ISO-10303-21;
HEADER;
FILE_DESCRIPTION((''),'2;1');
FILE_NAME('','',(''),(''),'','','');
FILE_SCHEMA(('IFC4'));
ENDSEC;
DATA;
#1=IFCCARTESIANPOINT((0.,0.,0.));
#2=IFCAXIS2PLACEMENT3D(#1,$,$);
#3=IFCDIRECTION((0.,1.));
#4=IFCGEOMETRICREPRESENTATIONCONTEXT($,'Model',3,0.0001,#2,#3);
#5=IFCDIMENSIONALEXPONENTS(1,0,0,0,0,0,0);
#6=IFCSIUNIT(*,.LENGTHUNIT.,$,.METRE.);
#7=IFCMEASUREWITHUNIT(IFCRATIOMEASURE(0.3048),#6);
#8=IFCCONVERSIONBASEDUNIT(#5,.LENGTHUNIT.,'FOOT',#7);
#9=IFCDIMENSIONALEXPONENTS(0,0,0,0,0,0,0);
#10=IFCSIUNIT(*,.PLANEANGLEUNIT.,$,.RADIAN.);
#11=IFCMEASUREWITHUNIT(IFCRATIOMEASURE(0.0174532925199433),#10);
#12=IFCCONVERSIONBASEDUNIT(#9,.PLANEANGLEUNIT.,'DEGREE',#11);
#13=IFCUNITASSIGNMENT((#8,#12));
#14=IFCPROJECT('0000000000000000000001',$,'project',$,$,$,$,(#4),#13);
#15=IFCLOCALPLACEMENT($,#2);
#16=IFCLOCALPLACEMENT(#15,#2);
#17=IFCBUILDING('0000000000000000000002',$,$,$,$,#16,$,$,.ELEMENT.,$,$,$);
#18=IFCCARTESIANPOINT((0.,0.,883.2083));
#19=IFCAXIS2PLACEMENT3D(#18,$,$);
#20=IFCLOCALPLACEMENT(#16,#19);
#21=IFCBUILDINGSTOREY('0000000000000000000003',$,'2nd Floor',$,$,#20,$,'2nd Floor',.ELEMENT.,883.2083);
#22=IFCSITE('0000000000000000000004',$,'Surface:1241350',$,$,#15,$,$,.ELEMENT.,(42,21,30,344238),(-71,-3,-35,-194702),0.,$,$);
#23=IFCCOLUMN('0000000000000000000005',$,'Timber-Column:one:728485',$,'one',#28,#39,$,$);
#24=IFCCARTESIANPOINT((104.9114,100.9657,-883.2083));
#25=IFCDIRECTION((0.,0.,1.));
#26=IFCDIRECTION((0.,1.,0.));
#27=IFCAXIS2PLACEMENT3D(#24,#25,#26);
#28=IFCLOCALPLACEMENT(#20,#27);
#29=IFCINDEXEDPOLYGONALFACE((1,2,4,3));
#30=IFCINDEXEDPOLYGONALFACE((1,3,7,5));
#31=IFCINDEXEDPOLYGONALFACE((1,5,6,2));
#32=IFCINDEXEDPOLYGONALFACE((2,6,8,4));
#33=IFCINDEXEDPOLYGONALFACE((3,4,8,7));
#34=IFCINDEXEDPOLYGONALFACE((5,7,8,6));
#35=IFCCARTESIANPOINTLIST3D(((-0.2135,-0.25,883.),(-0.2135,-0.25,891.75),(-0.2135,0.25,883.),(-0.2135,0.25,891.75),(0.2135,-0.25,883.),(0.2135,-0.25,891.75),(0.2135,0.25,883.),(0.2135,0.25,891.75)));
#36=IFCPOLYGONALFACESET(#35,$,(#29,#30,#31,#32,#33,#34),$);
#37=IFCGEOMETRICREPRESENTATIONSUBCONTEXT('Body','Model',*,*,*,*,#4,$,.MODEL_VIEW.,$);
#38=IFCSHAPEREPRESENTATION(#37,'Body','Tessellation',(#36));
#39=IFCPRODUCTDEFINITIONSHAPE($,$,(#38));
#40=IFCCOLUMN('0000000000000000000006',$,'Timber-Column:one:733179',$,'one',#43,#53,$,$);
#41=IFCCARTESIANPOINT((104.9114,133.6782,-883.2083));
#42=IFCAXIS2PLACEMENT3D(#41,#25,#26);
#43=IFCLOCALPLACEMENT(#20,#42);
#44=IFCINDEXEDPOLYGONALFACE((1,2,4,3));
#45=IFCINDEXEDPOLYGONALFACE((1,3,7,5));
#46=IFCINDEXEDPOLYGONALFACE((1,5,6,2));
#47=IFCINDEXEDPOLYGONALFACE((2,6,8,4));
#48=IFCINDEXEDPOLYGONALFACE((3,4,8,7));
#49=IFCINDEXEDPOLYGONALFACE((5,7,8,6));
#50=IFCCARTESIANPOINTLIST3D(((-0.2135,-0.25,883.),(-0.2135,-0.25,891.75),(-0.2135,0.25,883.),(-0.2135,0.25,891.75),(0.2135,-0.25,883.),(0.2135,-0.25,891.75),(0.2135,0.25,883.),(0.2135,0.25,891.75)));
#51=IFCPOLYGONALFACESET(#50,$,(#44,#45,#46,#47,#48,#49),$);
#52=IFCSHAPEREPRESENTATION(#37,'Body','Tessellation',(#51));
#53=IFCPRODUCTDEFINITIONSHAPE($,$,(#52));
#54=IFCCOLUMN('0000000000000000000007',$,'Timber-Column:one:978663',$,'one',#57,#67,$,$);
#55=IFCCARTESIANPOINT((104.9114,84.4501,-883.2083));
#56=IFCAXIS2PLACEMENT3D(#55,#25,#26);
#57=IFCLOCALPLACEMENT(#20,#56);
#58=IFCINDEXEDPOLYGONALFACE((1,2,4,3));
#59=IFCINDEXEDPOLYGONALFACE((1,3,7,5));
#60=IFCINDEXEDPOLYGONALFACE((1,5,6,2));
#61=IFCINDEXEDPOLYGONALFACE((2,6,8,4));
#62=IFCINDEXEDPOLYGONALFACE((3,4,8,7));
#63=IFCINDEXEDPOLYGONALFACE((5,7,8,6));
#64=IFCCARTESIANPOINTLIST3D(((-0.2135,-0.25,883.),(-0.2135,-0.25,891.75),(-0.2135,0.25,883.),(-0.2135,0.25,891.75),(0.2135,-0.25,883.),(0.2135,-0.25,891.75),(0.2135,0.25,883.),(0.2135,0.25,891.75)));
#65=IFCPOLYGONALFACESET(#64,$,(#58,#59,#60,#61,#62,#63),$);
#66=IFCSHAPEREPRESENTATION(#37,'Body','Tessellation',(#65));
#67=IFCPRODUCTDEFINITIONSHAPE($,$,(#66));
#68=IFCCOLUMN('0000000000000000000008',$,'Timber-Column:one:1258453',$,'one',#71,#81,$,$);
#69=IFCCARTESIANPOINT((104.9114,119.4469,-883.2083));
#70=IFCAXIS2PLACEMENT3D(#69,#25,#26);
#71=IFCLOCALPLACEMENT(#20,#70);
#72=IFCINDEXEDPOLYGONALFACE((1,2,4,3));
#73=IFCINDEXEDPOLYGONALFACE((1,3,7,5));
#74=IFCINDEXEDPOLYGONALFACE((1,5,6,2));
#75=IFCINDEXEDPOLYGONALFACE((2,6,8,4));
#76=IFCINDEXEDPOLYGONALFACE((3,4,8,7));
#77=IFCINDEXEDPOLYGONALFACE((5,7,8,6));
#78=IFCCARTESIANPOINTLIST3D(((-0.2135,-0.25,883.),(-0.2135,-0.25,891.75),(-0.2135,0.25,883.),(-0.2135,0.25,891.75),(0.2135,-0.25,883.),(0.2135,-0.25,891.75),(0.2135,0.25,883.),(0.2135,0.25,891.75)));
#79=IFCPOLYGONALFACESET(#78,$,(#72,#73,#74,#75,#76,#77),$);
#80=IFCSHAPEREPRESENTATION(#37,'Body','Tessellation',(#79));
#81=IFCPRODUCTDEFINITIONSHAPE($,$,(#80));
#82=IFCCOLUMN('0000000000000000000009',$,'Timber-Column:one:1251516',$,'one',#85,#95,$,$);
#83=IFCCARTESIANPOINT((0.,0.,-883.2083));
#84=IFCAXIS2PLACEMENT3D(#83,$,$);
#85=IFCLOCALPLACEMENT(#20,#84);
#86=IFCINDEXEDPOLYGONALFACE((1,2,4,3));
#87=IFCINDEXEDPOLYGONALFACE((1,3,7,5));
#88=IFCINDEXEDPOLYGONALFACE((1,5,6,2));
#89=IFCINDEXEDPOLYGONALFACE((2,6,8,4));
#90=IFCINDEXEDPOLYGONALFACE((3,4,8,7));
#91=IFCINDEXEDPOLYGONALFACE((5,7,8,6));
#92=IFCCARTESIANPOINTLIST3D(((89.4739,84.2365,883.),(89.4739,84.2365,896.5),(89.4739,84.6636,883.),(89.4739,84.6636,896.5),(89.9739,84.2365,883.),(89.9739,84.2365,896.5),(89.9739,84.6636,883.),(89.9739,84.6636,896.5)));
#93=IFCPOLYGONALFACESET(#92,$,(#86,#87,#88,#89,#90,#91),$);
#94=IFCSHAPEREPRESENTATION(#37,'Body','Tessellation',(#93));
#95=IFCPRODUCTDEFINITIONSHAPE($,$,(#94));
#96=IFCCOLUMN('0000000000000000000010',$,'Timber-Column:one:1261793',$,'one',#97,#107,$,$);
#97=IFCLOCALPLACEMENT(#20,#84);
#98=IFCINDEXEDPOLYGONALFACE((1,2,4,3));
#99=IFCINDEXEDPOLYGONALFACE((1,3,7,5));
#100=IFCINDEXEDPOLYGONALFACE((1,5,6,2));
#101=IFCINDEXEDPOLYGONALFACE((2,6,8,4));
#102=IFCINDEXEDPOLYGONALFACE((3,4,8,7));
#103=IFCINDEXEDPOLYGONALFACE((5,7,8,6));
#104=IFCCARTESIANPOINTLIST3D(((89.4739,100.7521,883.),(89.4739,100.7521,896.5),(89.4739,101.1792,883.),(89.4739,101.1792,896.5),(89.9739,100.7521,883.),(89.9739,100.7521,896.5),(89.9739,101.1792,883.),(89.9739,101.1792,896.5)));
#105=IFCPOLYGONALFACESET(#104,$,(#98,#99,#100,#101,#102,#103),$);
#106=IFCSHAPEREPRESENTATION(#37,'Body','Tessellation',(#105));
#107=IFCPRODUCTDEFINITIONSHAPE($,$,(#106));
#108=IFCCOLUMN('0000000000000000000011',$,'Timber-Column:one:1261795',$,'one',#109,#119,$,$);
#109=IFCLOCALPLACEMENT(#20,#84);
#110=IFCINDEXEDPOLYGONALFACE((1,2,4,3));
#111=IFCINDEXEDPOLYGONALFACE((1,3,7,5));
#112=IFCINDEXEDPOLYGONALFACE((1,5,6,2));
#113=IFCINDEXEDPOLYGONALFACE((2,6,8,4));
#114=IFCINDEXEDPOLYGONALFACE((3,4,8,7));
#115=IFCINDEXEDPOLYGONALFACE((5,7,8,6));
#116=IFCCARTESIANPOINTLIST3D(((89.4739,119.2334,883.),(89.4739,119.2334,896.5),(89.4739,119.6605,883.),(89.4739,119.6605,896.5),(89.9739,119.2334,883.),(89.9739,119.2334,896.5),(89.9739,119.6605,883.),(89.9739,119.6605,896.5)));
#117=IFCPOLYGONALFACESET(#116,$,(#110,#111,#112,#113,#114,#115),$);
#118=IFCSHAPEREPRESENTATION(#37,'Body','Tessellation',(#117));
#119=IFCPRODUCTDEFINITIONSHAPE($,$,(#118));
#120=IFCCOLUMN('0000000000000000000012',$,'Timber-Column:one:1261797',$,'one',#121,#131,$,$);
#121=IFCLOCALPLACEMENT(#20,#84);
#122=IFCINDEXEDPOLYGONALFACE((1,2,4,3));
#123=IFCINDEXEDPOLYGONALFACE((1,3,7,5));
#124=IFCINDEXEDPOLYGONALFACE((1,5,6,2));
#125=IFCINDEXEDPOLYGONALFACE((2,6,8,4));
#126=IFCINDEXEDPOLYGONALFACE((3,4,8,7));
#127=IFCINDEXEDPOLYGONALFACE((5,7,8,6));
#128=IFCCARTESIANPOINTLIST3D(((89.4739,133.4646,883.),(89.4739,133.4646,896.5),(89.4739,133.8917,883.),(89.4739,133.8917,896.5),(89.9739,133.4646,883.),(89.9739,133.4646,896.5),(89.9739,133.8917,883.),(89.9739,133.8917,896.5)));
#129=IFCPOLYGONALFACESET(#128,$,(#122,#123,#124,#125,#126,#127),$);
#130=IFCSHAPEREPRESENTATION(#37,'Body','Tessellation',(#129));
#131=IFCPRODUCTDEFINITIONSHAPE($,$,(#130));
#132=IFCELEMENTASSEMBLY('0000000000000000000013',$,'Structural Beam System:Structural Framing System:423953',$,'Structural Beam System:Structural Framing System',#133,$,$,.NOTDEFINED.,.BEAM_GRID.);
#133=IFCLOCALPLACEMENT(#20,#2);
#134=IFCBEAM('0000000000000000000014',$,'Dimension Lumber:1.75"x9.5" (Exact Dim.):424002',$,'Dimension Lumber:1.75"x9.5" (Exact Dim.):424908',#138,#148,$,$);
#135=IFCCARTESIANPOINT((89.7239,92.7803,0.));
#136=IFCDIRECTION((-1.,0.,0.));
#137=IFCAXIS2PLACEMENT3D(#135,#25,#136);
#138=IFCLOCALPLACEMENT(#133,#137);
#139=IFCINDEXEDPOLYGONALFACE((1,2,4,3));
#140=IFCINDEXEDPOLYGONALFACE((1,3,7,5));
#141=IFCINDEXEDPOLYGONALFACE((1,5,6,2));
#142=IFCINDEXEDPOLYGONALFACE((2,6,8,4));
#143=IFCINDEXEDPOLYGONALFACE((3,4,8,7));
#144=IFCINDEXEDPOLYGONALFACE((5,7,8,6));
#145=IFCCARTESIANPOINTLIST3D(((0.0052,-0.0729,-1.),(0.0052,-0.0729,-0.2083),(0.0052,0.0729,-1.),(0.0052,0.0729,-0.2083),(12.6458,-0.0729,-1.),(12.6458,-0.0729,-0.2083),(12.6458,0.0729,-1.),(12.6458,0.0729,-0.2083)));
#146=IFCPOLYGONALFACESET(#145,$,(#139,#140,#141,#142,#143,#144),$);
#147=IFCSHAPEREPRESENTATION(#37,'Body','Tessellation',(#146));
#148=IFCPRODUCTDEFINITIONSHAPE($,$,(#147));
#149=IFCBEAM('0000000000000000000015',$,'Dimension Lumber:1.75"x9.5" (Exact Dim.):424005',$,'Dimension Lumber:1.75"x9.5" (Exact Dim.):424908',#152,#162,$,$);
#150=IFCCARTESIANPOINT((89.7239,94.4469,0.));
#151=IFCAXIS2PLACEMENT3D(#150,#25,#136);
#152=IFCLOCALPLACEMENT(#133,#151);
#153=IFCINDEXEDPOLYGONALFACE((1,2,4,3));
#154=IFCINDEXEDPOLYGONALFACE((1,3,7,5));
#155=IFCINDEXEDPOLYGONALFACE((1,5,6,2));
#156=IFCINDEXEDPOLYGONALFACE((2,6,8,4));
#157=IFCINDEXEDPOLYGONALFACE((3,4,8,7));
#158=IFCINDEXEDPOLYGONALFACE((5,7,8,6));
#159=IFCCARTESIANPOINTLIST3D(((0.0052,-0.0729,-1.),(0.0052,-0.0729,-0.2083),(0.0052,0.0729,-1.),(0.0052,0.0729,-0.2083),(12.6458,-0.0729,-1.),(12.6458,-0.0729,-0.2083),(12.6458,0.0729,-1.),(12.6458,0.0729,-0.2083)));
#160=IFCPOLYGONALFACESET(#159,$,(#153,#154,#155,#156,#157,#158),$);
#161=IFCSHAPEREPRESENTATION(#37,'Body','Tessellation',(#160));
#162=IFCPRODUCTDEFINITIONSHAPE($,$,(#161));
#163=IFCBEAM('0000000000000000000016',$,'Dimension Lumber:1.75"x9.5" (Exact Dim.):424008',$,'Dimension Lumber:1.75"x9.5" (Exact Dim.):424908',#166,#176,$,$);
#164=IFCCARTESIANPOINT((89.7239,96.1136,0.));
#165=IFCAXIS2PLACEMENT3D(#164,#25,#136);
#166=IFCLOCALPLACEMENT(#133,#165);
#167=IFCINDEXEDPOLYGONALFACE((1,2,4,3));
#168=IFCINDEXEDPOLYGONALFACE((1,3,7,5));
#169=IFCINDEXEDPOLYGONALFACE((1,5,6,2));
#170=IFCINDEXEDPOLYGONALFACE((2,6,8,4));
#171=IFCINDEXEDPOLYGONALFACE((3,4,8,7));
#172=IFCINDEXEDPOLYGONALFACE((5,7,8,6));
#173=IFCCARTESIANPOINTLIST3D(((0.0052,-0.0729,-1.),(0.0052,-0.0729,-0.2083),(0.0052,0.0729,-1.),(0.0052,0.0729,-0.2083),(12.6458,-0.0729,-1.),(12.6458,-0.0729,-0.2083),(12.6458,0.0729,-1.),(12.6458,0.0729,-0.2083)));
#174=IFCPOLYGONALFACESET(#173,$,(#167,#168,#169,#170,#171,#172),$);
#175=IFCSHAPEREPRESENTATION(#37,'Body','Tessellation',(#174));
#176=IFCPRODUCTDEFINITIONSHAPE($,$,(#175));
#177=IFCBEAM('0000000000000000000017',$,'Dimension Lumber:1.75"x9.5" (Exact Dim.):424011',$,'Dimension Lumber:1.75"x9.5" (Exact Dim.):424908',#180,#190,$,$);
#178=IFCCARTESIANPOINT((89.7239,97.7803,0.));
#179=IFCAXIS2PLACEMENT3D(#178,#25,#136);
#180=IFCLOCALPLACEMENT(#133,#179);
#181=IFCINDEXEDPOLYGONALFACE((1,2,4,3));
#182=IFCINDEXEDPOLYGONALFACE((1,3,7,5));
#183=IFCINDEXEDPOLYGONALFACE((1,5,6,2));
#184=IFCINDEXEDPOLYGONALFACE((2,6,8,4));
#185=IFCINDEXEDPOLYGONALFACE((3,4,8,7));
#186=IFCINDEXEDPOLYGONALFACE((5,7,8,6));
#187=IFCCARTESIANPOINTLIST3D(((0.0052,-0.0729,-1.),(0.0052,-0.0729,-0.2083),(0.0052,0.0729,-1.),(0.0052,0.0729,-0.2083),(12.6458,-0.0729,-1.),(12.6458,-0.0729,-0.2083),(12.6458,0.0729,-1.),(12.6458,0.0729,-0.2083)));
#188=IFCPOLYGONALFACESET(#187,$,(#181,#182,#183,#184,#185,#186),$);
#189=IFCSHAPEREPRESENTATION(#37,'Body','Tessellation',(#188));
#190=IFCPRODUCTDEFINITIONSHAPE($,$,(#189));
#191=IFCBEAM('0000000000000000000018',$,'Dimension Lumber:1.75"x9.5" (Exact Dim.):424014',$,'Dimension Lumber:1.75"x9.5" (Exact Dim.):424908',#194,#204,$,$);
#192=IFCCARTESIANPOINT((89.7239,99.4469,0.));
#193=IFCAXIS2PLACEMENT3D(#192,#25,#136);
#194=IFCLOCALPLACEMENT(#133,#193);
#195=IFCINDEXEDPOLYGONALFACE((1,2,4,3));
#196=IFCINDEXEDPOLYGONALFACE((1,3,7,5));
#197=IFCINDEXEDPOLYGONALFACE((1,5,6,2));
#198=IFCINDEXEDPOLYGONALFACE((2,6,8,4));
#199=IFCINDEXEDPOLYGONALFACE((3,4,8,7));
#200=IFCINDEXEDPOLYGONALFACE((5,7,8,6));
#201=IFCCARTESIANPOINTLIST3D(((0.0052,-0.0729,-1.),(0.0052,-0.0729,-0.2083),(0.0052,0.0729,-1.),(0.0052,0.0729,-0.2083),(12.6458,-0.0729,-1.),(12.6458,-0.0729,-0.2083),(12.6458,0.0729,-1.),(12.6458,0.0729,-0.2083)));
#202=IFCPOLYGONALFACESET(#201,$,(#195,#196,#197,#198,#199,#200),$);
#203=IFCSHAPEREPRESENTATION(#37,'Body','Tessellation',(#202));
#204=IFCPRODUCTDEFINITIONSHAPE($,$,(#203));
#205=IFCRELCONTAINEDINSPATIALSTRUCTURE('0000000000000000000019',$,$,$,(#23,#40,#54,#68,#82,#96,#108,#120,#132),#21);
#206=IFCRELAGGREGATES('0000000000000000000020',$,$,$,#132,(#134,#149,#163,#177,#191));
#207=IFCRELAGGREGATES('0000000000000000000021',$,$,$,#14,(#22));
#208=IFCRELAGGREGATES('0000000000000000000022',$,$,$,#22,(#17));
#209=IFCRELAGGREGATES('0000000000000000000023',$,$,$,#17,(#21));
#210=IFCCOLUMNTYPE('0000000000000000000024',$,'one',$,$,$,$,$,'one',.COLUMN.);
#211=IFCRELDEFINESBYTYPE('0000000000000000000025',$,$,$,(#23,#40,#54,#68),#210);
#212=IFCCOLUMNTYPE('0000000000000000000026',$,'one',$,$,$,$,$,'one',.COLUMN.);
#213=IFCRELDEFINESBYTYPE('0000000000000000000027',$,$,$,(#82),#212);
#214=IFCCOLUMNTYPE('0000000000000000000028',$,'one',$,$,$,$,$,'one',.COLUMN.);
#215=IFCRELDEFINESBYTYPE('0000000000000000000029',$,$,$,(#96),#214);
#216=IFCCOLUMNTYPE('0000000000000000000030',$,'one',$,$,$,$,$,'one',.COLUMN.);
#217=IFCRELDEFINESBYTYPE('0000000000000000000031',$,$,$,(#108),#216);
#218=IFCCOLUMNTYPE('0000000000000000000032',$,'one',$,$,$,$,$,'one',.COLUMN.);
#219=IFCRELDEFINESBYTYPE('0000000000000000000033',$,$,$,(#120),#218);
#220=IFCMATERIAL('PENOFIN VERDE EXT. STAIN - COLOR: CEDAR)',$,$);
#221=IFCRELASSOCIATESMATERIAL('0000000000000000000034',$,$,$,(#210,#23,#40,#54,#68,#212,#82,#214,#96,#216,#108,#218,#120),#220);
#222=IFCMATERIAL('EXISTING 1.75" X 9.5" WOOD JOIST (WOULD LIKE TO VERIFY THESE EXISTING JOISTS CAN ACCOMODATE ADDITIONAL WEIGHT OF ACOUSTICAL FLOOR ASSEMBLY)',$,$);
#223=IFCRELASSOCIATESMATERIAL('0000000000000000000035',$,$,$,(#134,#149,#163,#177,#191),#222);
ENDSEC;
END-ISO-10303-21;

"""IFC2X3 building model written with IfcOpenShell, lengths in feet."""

from ifc_helpers import new_model, entity, si_unit, converted_unit, direction, frame, origin, origin_2d_with_axis, place, context, subcontext, project, spatial, rectangle, extrude, source, transform, mapped, material, type_object, type_shapes, element, aggregate, save


model = new_model("IFC2X3")

# Units and contexts
model_context = context("Model", 3, precision=0.0001, world=origin(), true_north=direction((0.0, 1.0)))
body_context = subcontext(model_context, "Body", "Model", "MODEL_VIEW")
ifc_project = project(units=[converted_unit("LENGTHUNIT", "FOOT", entity("IfcRatioMeasure", 0.3048), si_unit("LENGTHUNIT", "METRE"), dimensions=[1, 0, 0, 0, 0, 0, 0]), converted_unit("PLANEANGLEUNIT", "DEGREE", entity("IfcRatioMeasure", 0.0174532925199433), si_unit("PLANEANGLEUNIT", "RADIAN"), dimensions=[0, 0, 0, 0, 0, 0, 0])], contexts=[model_context])

# Site, building, storey
site_placement = place(None, origin())
site = spatial("IfcSite", under=ifc_project, at=site_placement, Name="Surface:1241350", CompositionType="ELEMENT", RefLatitude=(42, 21, 30, 344238), RefLongitude=(-71, -3, -35, -194702), RefElevation=0.0)
building_placement = place(site_placement, origin())
building = spatial("IfcBuilding", under=site, at=building_placement, CompositionType="ELEMENT")
storey_placement = place(building_placement, frame((0.0, 0.0, 883.2083)))
storey = spatial("IfcBuildingStorey", under=building, at=storey_placement, Name="2nd Floor", LongName="2nd Floor", CompositionType="ELEMENT", Elevation=883.2083)

# Columns
ifc_material_1 = material(Name="PENOFIN VERDE EXT. STAIN - COLOR: CEDAR)")
column_type_1 = type_object("IfcColumnType", Name="one", ElementType="one", PredefinedType="COLUMN", material=ifc_material_1)
shared_shape_1 = source(origin(), body_context, "Body", "SweptSolid", [
    extrude(rectangle(XDim=0.5, YDim=0.4271, at=origin_2d_with_axis()), frame((0.0, 0.0, 883.0), z_axis=(0.0, 0.0, 1.0), x_axis=(0.0, -1.0, 0.0)), (0.0, 0.0, 1.0), 8.75),
])
type_shapes(column_type_1, [shared_shape_1])
for number, where, z_axis, x_axis, name in (
    (1, (104.9114, 100.9657, -883.2083), (0.0, 0.0, 1.0), (0.0, 1.0, 0.0), "Timber-Column:one:728485"),
    (2, (104.9114, 133.6782, -883.2083), (0.0, 0.0, 1.0), (0.0, 1.0, 0.0), "Timber-Column:one:733179"),
    (3, (104.9114, 84.4501, -883.2083), (0.0, 0.0, 1.0), (0.0, 1.0, 0.0), "Timber-Column:one:978663"),
    (4, (104.9114, 119.4469, -883.2083), (0.0, 0.0, 1.0), (0.0, 1.0, 0.0), "Timber-Column:one:1258453"),
):
    element("IfcColumn", number, at=place(storey_placement, frame(where, z_axis=z_axis, x_axis=x_axis)), inside=storey, type_object=column_type_1, material=ifc_material_1, Name=name, ObjectType="one", context=body_context, shape_type="MappedRepresentation", body=[
        mapped(shared_shape_1, transform((0.0, 0.0, 0.0), scale=1.0)),
    ])
column_type_2 = type_object("IfcColumnType", Name="one", ElementType="one", PredefinedType="COLUMN", material=ifc_material_1)
shared_shape_2 = source(origin(), body_context, "Body", "SweptSolid", [
    extrude(rectangle(XDim=0.4271, YDim=0.5, at=origin_2d_with_axis()), frame((89.7239, 84.4501, 883.0), z_axis=(0.0, 0.0, 1.0), x_axis=(0.0, -1.0, 0.0)), (0.0, 0.0, 1.0), 13.5),
])
type_shapes(column_type_2, [shared_shape_2])
column_1_placement = place(storey_placement, frame((0.0, 0.0, -883.2083)))
element("IfcColumn", 5, at=column_1_placement, inside=storey, type_object=column_type_2, material=ifc_material_1, Name="Timber-Column:one:1251516", ObjectType="one", context=body_context, shape_type="MappedRepresentation", body=[
    mapped(shared_shape_2, transform((0.0, 0.0, 0.0), scale=1.0)),
])
column_type_3 = type_object("IfcColumnType", Name="one", ElementType="one", PredefinedType="COLUMN", material=ifc_material_1)
shared_shape_3 = source(origin(), body_context, "Body", "SweptSolid", [
    extrude(rectangle(XDim=0.4271, YDim=0.5, at=origin_2d_with_axis()), frame((89.7239, 100.9657, 883.0), z_axis=(0.0, 0.0, 1.0), x_axis=(0.0, -1.0, 0.0)), (0.0, 0.0, 1.0), 13.5),
])
type_shapes(column_type_3, [shared_shape_3])
column_2_placement = place(storey_placement, frame((0.0, 0.0, -883.2083)))
element("IfcColumn", 6, at=column_2_placement, inside=storey, type_object=column_type_3, material=ifc_material_1, Name="Timber-Column:one:1261793", ObjectType="one", context=body_context, shape_type="MappedRepresentation", body=[
    mapped(shared_shape_3, transform((0.0, 0.0, 0.0), scale=1.0)),
])
column_type_4 = type_object("IfcColumnType", Name="one", ElementType="one", PredefinedType="COLUMN", material=ifc_material_1)
shared_shape_4 = source(origin(), body_context, "Body", "SweptSolid", [
    extrude(rectangle(XDim=0.4271, YDim=0.5, at=origin_2d_with_axis()), frame((89.7239, 119.4469, 883.0), z_axis=(0.0, 0.0, 1.0), x_axis=(0.0, -1.0, 0.0)), (0.0, 0.0, 1.0), 13.5),
])
type_shapes(column_type_4, [shared_shape_4])
column_3_placement = place(storey_placement, frame((0.0, 0.0, -883.2083)))
element("IfcColumn", 7, at=column_3_placement, inside=storey, type_object=column_type_4, material=ifc_material_1, Name="Timber-Column:one:1261795", ObjectType="one", context=body_context, shape_type="MappedRepresentation", body=[
    mapped(shared_shape_4, transform((0.0, 0.0, 0.0), scale=1.0)),
])
column_type_5 = type_object("IfcColumnType", Name="one", ElementType="one", PredefinedType="COLUMN", material=ifc_material_1)
shared_shape_5 = source(origin(), body_context, "Body", "SweptSolid", [
    extrude(rectangle(XDim=0.4271, YDim=0.5, at=origin_2d_with_axis()), frame((89.7239, 133.6782, 883.0), z_axis=(0.0, 0.0, 1.0), x_axis=(0.0, -1.0, 0.0)), (0.0, 0.0, 1.0), 13.5),
])
type_shapes(column_type_5, [shared_shape_5])
column_4_placement = place(storey_placement, frame((0.0, 0.0, -883.2083)))
element("IfcColumn", 8, at=column_4_placement, inside=storey, type_object=column_type_5, material=ifc_material_1, Name="Timber-Column:one:1261797", ObjectType="one", context=body_context, shape_type="MappedRepresentation", body=[
    mapped(shared_shape_5, transform((0.0, 0.0, 0.0), scale=1.0)),
])

# Element assembly, beams
assembly_placement = place(storey_placement, origin())
assembly = element("IfcElementAssembly", 9, at=assembly_placement, inside=storey, Name="Structural Beam System:Structural Framing System:423953", ObjectType="Structural Beam System:Structural Framing System", AssemblyPlace="NOTDEFINED", PredefinedType="BEAM_GRID")
ifc_material_2 = material(Name="EXISTING 1.75\" X 9.5\" WOOD JOIST (WOULD LIKE TO VERIFY THESE EXISTING JOISTS CAN ACCOMODATE ADDITIONAL WEIGHT OF ACOUSTICAL FLOOR ASSEMBLY)")
beam_1_placement = place(assembly_placement, frame((89.7239, 92.7803, 0.0), z_axis=(0.0, 0.0, 1.0), x_axis=(-1.0, 0.0, 0.0)))
beam_1 = element("IfcBeam", 10, at=beam_1_placement, material=ifc_material_2, Name="Dimension Lumber:1.75\"x9.5\" (Exact Dim.):424002", ObjectType="Dimension Lumber:1.75\"x9.5\" (Exact Dim.):424908", context=body_context, shape_type="SweptSolid", body=[
    extrude(rectangle(XDim=0.7917, YDim=0.1458, at=origin_2d_with_axis()), frame((0.0052, 0.0, -0.6042), z_axis=(1.0, 0.0, 0.0), x_axis=(0.0, 0.0, -1.0)), (0.0, 0.0, 1.0), 12.6406),
])
beam_2_placement = place(assembly_placement, frame((89.7239, 94.4469, 0.0), z_axis=(0.0, 0.0, 1.0), x_axis=(-1.0, 0.0, 0.0)))
beam_2 = element("IfcBeam", 11, at=beam_2_placement, material=ifc_material_2, Name="Dimension Lumber:1.75\"x9.5\" (Exact Dim.):424005", ObjectType="Dimension Lumber:1.75\"x9.5\" (Exact Dim.):424908", context=body_context, shape_type="SweptSolid", body=[
    extrude(rectangle(XDim=0.7917, YDim=0.1458, at=origin_2d_with_axis()), frame((0.0052, 0.0, -0.6042), z_axis=(1.0, 0.0, 0.0), x_axis=(0.0, 0.0, -1.0)), (0.0, 0.0, 1.0), 12.6406),
])
beam_3_placement = place(assembly_placement, frame((89.7239, 96.1136, 0.0), z_axis=(0.0, 0.0, 1.0), x_axis=(-1.0, 0.0, 0.0)))
beam_3 = element("IfcBeam", 12, at=beam_3_placement, material=ifc_material_2, Name="Dimension Lumber:1.75\"x9.5\" (Exact Dim.):424008", ObjectType="Dimension Lumber:1.75\"x9.5\" (Exact Dim.):424908", context=body_context, shape_type="SweptSolid", body=[
    extrude(rectangle(XDim=0.7917, YDim=0.1458, at=origin_2d_with_axis()), frame((0.0052, 0.0, -0.6042), z_axis=(1.0, 0.0, 0.0), x_axis=(0.0, 0.0, -1.0)), (0.0, 0.0, 1.0), 12.6406),
])
beam_4_placement = place(assembly_placement, frame((89.7239, 97.7803, 0.0), z_axis=(0.0, 0.0, 1.0), x_axis=(-1.0, 0.0, 0.0)))
beam_4 = element("IfcBeam", 13, at=beam_4_placement, material=ifc_material_2, Name="Dimension Lumber:1.75\"x9.5\" (Exact Dim.):424011", ObjectType="Dimension Lumber:1.75\"x9.5\" (Exact Dim.):424908", context=body_context, shape_type="SweptSolid", body=[
    extrude(rectangle(XDim=0.7917, YDim=0.1458, at=origin_2d_with_axis()), frame((0.0052, 0.0, -0.6042), z_axis=(1.0, 0.0, 0.0), x_axis=(0.0, 0.0, -1.0)), (0.0, 0.0, 1.0), 12.6406),
])
beam_5_placement = place(assembly_placement, frame((89.7239, 99.4469, 0.0), z_axis=(0.0, 0.0, 1.0), x_axis=(-1.0, 0.0, 0.0)))
beam_5 = element("IfcBeam", 14, at=beam_5_placement, material=ifc_material_2, Name="Dimension Lumber:1.75\"x9.5\" (Exact Dim.):424014", ObjectType="Dimension Lumber:1.75\"x9.5\" (Exact Dim.):424908", context=body_context, shape_type="SweptSolid", body=[
    extrude(rectangle(XDim=0.7917, YDim=0.1458, at=origin_2d_with_axis()), frame((0.0052, 0.0, -0.6042), z_axis=(1.0, 0.0, 0.0), x_axis=(0.0, 0.0, -1.0)), (0.0, 0.0, 1.0), 12.6406),
])
aggregate(assembly, [beam_1, beam_2, beam_3, beam_4, beam_5])

save(model, "model.ifc")
